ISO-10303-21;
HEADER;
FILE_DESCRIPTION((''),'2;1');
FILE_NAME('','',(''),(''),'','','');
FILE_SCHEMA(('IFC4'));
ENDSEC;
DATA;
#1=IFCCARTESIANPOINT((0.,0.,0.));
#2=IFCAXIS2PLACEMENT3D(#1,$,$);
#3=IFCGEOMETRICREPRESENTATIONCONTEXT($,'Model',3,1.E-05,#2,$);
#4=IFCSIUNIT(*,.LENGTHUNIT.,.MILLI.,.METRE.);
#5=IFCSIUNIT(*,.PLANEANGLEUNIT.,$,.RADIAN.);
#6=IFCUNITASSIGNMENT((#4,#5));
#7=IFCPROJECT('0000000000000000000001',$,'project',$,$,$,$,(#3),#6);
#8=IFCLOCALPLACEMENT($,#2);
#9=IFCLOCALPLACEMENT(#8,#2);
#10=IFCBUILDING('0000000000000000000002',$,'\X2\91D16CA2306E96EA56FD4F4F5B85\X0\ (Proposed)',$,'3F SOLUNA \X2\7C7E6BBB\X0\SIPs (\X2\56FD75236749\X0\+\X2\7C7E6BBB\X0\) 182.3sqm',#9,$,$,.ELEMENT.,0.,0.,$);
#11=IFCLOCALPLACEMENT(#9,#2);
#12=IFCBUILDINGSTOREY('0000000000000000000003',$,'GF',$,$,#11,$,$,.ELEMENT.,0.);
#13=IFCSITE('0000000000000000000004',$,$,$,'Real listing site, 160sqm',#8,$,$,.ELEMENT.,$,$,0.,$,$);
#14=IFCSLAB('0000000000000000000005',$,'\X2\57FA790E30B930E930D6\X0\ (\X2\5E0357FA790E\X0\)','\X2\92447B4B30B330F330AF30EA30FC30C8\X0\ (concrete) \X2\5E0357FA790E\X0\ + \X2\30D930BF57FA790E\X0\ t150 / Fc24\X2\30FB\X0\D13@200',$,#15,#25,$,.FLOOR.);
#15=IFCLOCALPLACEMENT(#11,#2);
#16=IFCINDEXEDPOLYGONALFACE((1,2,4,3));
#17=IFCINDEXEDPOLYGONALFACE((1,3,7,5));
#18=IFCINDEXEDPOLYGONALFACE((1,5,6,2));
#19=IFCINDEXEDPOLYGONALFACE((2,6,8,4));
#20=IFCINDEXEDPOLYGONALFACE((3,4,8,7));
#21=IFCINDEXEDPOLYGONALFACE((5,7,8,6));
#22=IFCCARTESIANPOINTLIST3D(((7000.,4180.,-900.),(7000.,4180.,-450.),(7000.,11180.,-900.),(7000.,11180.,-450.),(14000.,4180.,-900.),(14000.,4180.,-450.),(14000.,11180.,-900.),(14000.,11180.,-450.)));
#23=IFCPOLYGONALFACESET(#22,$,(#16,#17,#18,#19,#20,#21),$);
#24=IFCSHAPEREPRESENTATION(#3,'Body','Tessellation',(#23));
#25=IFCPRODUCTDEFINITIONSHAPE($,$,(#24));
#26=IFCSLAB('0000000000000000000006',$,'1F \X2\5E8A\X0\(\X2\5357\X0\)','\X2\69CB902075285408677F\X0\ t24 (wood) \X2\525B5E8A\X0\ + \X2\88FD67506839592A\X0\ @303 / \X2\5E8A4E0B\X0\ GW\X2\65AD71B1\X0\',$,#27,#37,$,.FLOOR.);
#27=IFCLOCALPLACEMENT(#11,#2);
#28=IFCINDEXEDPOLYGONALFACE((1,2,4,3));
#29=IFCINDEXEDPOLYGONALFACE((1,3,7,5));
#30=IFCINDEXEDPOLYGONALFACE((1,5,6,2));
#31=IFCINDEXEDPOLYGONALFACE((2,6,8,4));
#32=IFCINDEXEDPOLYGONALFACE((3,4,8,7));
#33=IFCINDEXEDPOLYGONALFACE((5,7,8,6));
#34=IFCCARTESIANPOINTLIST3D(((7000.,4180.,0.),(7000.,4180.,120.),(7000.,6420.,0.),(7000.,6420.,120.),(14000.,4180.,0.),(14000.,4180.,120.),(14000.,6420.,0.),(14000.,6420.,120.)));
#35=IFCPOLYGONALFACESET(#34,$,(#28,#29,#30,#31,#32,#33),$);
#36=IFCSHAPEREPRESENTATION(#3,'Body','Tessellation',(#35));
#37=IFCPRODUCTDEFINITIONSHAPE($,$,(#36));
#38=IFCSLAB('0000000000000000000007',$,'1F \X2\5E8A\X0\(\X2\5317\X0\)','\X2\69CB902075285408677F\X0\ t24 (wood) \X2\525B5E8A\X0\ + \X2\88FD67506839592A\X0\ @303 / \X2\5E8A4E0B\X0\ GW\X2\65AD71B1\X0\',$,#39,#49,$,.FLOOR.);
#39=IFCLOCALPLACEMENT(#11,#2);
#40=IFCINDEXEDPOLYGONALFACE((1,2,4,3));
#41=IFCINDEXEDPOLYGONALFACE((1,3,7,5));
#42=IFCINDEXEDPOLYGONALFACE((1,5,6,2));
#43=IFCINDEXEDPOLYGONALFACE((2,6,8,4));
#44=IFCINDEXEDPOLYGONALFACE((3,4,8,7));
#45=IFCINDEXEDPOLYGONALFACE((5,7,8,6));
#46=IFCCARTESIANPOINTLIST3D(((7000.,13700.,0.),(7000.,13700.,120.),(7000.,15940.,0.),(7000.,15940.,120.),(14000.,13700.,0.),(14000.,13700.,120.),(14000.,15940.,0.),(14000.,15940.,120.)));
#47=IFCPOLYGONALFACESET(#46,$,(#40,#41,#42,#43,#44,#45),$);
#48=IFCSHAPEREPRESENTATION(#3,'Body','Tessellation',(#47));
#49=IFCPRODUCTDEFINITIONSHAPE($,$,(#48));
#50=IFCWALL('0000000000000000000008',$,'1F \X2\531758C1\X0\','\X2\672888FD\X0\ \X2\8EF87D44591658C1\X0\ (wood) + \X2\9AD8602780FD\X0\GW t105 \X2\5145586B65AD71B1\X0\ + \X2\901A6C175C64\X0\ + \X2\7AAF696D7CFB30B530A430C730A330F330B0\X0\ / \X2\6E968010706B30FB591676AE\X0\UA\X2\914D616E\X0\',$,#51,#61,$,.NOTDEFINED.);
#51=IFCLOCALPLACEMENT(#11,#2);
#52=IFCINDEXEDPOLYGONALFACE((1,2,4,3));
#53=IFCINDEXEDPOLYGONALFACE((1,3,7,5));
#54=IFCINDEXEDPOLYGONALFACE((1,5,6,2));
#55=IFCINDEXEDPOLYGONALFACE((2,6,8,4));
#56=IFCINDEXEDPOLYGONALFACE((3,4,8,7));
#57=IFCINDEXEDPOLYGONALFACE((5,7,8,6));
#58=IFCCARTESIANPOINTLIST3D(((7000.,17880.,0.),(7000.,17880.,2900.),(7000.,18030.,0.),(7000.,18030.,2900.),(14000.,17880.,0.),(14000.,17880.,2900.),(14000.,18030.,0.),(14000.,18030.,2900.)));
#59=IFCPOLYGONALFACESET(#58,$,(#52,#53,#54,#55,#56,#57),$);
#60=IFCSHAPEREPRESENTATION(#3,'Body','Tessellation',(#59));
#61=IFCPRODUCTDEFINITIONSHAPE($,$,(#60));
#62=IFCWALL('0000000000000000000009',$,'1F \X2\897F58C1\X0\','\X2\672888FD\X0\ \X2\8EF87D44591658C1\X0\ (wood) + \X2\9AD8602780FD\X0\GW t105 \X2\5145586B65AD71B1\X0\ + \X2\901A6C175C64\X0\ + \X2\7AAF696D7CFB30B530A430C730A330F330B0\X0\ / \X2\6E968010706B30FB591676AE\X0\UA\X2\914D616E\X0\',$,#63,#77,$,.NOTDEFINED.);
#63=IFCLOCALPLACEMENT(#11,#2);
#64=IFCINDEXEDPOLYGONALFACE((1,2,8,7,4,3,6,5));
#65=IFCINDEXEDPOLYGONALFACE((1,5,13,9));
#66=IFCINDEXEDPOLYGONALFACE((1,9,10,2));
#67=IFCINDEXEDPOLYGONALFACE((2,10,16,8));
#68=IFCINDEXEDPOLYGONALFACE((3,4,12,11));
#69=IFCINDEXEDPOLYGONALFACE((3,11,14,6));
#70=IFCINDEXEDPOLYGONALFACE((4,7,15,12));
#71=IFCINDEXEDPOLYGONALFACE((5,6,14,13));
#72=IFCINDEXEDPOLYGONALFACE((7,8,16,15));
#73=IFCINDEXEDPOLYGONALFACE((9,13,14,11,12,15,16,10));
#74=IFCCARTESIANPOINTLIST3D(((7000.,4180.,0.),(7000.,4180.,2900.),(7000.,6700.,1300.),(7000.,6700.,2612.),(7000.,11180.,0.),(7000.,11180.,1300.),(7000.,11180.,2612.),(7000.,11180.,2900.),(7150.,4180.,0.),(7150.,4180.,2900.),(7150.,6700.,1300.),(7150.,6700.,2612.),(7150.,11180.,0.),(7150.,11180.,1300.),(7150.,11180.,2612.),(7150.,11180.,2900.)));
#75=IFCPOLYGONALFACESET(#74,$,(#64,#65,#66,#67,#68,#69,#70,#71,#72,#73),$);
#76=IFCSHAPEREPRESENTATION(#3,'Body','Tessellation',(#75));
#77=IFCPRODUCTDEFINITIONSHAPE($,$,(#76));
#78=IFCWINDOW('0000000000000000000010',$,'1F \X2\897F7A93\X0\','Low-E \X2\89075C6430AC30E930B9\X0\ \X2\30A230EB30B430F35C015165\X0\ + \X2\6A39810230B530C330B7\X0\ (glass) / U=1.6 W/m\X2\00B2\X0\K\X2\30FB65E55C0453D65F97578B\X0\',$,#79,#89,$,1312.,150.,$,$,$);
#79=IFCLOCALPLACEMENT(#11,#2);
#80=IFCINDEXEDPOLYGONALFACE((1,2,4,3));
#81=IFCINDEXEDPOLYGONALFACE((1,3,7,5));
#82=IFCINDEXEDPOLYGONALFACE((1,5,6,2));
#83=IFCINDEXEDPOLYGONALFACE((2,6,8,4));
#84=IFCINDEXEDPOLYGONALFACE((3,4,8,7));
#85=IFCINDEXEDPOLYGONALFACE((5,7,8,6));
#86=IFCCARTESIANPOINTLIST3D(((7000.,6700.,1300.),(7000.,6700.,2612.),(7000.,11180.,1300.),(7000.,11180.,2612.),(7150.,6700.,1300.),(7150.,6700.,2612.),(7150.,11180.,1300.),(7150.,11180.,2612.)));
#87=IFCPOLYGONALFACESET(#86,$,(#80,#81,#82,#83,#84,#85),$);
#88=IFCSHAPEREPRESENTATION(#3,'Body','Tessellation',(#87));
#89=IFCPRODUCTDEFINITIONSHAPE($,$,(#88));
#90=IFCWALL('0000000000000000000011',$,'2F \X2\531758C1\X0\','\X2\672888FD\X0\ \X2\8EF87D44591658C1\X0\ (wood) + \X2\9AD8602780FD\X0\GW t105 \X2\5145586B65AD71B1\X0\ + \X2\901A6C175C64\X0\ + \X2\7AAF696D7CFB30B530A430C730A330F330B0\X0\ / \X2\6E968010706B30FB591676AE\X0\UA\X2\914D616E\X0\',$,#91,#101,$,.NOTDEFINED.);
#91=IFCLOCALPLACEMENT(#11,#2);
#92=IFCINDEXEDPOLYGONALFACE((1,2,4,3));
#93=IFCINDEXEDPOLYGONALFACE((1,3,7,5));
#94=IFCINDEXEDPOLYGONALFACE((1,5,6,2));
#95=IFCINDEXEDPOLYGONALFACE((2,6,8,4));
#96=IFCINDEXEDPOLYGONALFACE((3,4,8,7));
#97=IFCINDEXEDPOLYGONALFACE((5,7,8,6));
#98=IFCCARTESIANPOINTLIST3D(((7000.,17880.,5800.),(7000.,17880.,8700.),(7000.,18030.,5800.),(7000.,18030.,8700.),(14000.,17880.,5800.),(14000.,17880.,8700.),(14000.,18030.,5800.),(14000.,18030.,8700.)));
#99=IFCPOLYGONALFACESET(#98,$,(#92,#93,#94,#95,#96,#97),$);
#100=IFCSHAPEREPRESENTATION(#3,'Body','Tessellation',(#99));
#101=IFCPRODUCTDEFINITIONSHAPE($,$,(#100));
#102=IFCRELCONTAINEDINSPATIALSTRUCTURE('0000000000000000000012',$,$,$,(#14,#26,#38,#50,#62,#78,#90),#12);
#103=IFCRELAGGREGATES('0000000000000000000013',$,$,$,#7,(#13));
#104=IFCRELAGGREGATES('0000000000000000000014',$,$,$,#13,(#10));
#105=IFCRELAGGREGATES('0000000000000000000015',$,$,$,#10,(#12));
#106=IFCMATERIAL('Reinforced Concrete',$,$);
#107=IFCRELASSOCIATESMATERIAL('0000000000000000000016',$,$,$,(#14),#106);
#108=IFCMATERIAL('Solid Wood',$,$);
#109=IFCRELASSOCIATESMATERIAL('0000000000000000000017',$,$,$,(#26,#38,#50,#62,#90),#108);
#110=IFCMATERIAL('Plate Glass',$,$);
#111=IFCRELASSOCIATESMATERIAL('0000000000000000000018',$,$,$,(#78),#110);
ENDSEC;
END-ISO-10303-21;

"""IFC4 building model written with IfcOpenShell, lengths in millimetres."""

from ifc_helpers import new_model, si_unit, frame, frame_2d, origin, place, context, project, spatial, rectangle, extrude, material, element, fill, save


model = new_model("IFC4")

# Units and contexts
model_context = context("Model", 3, precision=1e-05, world=origin())
ifc_project = project(units=[si_unit("LENGTHUNIT", "METRE", prefix="MILLI"), si_unit("PLANEANGLEUNIT", "RADIAN")], contexts=[model_context])

# Site, building, storey
site_placement = place(None, origin())
site = spatial("IfcSite", under=ifc_project, at=site_placement, ObjectType="Real listing site, 160sqm", CompositionType="ELEMENT", RefElevation=0.0)
building_placement = place(site_placement, origin())
building = spatial("IfcBuilding", under=site, at=building_placement, Name="金沢の雪国住宅 (Proposed)", ObjectType="3F SOLUNA 籾殻SIPs (国産杉+籾殻) 182.3sqm", CompositionType="ELEMENT", ElevationOfRefHeight=0.0, ElevationOfTerrain=0.0)
storey_placement = place(building_placement, origin())
storey = spatial("IfcBuildingStorey", under=building, at=storey_placement, Name="GF", CompositionType="ELEMENT", Elevation=0.0)

# Slabs
ifc_material_1 = material(Name="Reinforced Concrete")
slab_1_placement = place(storey_placement, frame((3500.0, 2090.0, -450.0)))
element("IfcSlab", 1, at=slab_1_placement, inside=storey, material=ifc_material_1, Name="基礎スラブ (布基礎)", Description="鉄筋コンクリート (concrete) 布基礎 + ベタ基礎 t150 / Fc24・D13@200", PredefinedType="FLOOR", context=model_context, shape_type="SweptSolid", body=[
    extrude(rectangle(XDim=7000.0, YDim=7000.0, at=frame_2d((3500.0, 3500.0))), frame((3500.0, 2090.0, -450.0)), (0.0, 0.0, 1.0), 450.0),
])
ifc_material_2 = material(Name="Solid Wood")
slab_2_placement = place(storey_placement, frame((3500.0, 2090.0, 0.0)))
element("IfcSlab", 2, at=slab_2_placement, inside=storey, material=ifc_material_2, Name="1F 床(南)", Description="構造用合板 t24 (wood) 剛床 + 製材根太 @303 / 床下 GW断熱", PredefinedType="FLOOR", context=model_context, shape_type="SweptSolid", body=[
    extrude(rectangle(XDim=7000.0, YDim=2240.0, at=frame_2d((3500.0, 1120.0))), frame((3500.0, 2090.0, 0.0)), (0.0, 0.0, 1.0), 120.0),
])
slab_3_placement = place(storey_placement, frame((3500.0, 6850.0, 0.0)))
element("IfcSlab", 3, at=slab_3_placement, inside=storey, material=ifc_material_2, Name="1F 床(北)", Description="構造用合板 t24 (wood) 剛床 + 製材根太 @303 / 床下 GW断熱", PredefinedType="FLOOR", context=model_context, shape_type="SweptSolid", body=[
    extrude(rectangle(XDim=7000.0, YDim=2240.0, at=frame_2d((3500.0, 1120.0))), frame((3500.0, 6850.0, 0.0)), (0.0, 0.0, 1.0), 120.0),
])

# Shared definitions
ifc_material_3 = material(Name="Plate Glass")

# Wall
wall_1_placement = place(storey_placement, frame((3500.0, 8940.0, 0.0)))
element("IfcWall", 4, at=wall_1_placement, inside=storey, material=ifc_material_2, Name="1F 北壁", Description="木製 軸組外壁 (wood) + 高性能GW t105 充填断熱 + 通気層 + 窯業系サイディング / 準耐火・外皮UA配慮", PredefinedType="NOTDEFINED", context=model_context, shape_type="SweptSolid", body=[
    extrude(rectangle(XDim=7000.0, YDim=150.0, at=frame_2d((3500.0, 75.0))), frame((3500.0, 8940.0, 0.0)), (0.0, 0.0, 1.0), 2900.0),
])

# Wall, opening, window
wall_2_placement = place(storey_placement, frame((3500.0, 2090.0, 0.0)))
wall_2 = element("IfcWall", 5, at=wall_2_placement, inside=storey, material=ifc_material_2, Name="1F 西壁", Description="木製 軸組外壁 (wood) + 高性能GW t105 充填断熱 + 通気層 + 窯業系サイディング / 準耐火・外皮UA配慮", PredefinedType="NOTDEFINED", context=model_context, shape_type="SweptSolid", body=[
    extrude(rectangle(XDim=150.0, YDim=7000.0, at=frame_2d((75.0, 3500.0))), frame((3500.0, 2090.0, 0.0)), (0.0, 0.0, 1.0), 2900.0),
])
opening_1_placement = place(storey_placement, frame((3500.0, 3350.0, 650.0)))
opening_1 = element("IfcOpeningElement", 6, at=opening_1_placement, cuts=wall_2, PredefinedType="NOTDEFINED", context=model_context, shape_type="SweptSolid", body=[
    extrude(rectangle(XDim=150.0, YDim=4480.0, at=frame_2d((75.0, 2240.0))), frame((3500.0, 3350.0, 650.0)), (0.0, 0.0, 1.0), 1312.0),
])
window_1_placement = place(storey_placement, frame((3500.0, 3350.0, 650.0)))
window_1 = element("IfcWindow", 7, at=window_1_placement, inside=storey, material=ifc_material_3, Name="1F 西窓", Description="Low-E 複層ガラス アルゴン封入 + 樹脂サッシ (glass) / U=1.6 W/m²K・日射取得型", OverallHeight=1312.0, OverallWidth=150.0, context=model_context, shape_type="SweptSolid", body=[
    extrude(rectangle(XDim=150.0, YDim=4480.0, at=frame_2d((75.0, 2240.0))), frame((3500.0, 3350.0, 650.0)), (0.0, 0.0, 1.0), 1312.0),
])
fill(opening_1, window_1)

# Wall
wall_3_placement = place(storey_placement, frame((3500.0, 8940.0, 2900.0)))
element("IfcWall", 8, at=wall_3_placement, inside=storey, material=ifc_material_2, Name="2F 北壁", Description="木製 軸組外壁 (wood) + 高性能GW t105 充填断熱 + 通気層 + 窯業系サイディング / 準耐火・外皮UA配慮", PredefinedType="NOTDEFINED", context=model_context, shape_type="SweptSolid", body=[
    extrude(rectangle(XDim=7000.0, YDim=150.0, at=frame_2d((3500.0, 75.0))), frame((3500.0, 8940.0, 2900.0)), (0.0, 0.0, 1.0), 2900.0),
])

save(model, "model.ifc")
